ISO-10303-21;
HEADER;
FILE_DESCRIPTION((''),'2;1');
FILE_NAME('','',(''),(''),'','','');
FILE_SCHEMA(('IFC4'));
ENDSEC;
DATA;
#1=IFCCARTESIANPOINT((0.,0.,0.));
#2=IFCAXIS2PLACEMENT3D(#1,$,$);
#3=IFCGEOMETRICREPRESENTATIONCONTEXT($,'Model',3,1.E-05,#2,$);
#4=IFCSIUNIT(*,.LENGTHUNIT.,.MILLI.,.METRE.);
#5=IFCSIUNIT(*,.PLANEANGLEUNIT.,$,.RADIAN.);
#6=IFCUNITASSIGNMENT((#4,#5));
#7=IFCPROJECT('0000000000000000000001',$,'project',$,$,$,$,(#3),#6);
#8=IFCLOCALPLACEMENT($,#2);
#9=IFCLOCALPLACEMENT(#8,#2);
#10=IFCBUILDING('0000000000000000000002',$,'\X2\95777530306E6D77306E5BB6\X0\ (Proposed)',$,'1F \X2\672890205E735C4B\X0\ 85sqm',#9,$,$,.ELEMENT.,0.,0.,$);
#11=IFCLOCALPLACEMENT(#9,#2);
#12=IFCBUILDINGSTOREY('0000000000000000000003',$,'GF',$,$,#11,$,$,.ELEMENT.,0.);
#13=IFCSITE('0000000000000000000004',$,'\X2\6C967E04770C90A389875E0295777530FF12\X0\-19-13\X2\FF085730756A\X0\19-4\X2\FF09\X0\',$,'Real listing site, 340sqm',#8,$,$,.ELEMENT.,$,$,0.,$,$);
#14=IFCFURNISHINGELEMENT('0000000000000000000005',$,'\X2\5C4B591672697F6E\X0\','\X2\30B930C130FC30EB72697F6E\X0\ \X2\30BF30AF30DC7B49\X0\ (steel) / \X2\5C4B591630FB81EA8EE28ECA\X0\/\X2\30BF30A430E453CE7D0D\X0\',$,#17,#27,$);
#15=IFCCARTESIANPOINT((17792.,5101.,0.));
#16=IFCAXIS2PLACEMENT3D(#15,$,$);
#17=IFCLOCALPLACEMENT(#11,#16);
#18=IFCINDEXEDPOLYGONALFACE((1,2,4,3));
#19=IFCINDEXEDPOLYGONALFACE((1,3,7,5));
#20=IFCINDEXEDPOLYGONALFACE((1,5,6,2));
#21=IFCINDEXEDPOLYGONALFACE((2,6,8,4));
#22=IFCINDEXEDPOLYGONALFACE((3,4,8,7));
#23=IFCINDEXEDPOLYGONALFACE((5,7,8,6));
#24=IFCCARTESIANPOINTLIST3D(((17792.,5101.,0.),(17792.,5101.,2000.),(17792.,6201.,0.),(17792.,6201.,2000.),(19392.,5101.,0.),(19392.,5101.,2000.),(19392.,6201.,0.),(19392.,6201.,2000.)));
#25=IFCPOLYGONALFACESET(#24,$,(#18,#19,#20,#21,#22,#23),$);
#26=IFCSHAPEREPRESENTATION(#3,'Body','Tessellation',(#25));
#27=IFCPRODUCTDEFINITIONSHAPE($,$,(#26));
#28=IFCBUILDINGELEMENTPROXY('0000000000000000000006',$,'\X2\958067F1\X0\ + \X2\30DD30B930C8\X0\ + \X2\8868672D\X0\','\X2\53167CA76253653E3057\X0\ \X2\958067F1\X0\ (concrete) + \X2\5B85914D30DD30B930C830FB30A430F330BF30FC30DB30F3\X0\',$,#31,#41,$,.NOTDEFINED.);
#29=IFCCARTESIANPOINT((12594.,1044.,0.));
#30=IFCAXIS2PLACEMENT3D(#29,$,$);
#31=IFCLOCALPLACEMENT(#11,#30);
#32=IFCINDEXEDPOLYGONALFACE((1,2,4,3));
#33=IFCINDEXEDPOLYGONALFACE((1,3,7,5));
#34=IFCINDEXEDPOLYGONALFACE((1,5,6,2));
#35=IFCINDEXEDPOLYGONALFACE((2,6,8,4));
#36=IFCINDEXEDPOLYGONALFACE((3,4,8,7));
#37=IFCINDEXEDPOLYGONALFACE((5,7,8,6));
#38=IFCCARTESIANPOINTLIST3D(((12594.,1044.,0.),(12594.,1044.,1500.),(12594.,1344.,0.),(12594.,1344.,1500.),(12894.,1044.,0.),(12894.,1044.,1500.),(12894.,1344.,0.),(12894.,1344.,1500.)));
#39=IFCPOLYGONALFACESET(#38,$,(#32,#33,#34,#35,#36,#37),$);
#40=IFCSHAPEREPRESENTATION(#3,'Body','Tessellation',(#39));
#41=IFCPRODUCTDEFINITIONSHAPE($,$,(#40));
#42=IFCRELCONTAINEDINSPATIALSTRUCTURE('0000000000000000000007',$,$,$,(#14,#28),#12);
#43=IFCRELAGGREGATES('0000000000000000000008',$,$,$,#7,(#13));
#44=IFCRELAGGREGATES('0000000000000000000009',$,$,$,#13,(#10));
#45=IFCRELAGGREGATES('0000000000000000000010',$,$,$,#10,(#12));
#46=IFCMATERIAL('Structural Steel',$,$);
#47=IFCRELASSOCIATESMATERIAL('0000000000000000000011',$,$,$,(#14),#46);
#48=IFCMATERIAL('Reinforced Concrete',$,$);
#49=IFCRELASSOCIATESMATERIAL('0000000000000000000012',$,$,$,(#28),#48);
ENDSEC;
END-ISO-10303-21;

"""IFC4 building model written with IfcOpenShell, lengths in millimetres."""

from ifc_helpers import new_model, si_unit, frame, frame_2d, origin, place, context, project, spatial, rectangle, extrude, material, element, save


model = new_model("IFC4")

# Units and contexts
model_context = context("Model", 3, precision=1e-05, world=origin())
ifc_project = project(units=[si_unit("LENGTHUNIT", "METRE", prefix="MILLI"), si_unit("PLANEANGLEUNIT", "RADIAN")], contexts=[model_context])

# Site, building, storey
site_placement = place(None, origin())
site = spatial("IfcSite", under=ifc_project, at=site_placement, Name="沖縄県那覇市長田２-19-13（地番19-4）", ObjectType="Real listing site, 340sqm", CompositionType="ELEMENT", RefElevation=0.0)
building_placement = place(site_placement, origin())
building = spatial("IfcBuilding", under=site, at=building_placement, Name="長田の海の家 (Proposed)", ObjectType="1F 木造平屋 85sqm", CompositionType="ELEMENT", ElevationOfRefHeight=0.0, ElevationOfTerrain=0.0)
storey_placement = place(building_placement, origin())
storey = spatial("IfcBuildingStorey", under=building, at=storey_placement, Name="GF", CompositionType="ELEMENT", Elevation=0.0)

# Shared definitions
ifc_material_1 = material(Name="Reinforced Concrete")

# Shared definitions
ifc_material_2 = material(Name="Structural Steel")

# Furnishing element
furnishing_1_placement = place(storey_placement, frame((17792.0, 5101.0, 0.0)))
element("IfcFurnishingElement", 1, at=furnishing_1_placement, inside=storey, material=ifc_material_2, Name="屋外物置", Description="スチール物置 タクボ等 (steel) / 屋外・自転車/タイヤ収納", context=model_context, shape_type="SweptSolid", body=[
    extrude(rectangle(XDim=1600.0, YDim=1100.0, at=frame_2d((800.0, 550.0))), frame((17792.0, 5101.0, 0.0)), (0.0, 0.0, 1.0), 2000.0),
])

# Building element proxy
proxy_placement = place(storey_placement, frame((12594.0, 1044.0, 0.0)))
element("IfcBuildingElementProxy", 2, at=proxy_placement, inside=storey, material=ifc_material_1, Name="門柱 + ポスト + 表札", Description="化粧打放し 門柱 (concrete) + 宅配ポスト・インターホン", PredefinedType="NOTDEFINED", context=model_context, shape_type="SweptSolid", body=[
    extrude(rectangle(XDim=300.0, YDim=300.0, at=frame_2d((150.0, 150.0))), frame((12594.0, 1044.0, 0.0)), (0.0, 0.0, 1.0), 1500.0),
])

save(model, "model.ifc")
